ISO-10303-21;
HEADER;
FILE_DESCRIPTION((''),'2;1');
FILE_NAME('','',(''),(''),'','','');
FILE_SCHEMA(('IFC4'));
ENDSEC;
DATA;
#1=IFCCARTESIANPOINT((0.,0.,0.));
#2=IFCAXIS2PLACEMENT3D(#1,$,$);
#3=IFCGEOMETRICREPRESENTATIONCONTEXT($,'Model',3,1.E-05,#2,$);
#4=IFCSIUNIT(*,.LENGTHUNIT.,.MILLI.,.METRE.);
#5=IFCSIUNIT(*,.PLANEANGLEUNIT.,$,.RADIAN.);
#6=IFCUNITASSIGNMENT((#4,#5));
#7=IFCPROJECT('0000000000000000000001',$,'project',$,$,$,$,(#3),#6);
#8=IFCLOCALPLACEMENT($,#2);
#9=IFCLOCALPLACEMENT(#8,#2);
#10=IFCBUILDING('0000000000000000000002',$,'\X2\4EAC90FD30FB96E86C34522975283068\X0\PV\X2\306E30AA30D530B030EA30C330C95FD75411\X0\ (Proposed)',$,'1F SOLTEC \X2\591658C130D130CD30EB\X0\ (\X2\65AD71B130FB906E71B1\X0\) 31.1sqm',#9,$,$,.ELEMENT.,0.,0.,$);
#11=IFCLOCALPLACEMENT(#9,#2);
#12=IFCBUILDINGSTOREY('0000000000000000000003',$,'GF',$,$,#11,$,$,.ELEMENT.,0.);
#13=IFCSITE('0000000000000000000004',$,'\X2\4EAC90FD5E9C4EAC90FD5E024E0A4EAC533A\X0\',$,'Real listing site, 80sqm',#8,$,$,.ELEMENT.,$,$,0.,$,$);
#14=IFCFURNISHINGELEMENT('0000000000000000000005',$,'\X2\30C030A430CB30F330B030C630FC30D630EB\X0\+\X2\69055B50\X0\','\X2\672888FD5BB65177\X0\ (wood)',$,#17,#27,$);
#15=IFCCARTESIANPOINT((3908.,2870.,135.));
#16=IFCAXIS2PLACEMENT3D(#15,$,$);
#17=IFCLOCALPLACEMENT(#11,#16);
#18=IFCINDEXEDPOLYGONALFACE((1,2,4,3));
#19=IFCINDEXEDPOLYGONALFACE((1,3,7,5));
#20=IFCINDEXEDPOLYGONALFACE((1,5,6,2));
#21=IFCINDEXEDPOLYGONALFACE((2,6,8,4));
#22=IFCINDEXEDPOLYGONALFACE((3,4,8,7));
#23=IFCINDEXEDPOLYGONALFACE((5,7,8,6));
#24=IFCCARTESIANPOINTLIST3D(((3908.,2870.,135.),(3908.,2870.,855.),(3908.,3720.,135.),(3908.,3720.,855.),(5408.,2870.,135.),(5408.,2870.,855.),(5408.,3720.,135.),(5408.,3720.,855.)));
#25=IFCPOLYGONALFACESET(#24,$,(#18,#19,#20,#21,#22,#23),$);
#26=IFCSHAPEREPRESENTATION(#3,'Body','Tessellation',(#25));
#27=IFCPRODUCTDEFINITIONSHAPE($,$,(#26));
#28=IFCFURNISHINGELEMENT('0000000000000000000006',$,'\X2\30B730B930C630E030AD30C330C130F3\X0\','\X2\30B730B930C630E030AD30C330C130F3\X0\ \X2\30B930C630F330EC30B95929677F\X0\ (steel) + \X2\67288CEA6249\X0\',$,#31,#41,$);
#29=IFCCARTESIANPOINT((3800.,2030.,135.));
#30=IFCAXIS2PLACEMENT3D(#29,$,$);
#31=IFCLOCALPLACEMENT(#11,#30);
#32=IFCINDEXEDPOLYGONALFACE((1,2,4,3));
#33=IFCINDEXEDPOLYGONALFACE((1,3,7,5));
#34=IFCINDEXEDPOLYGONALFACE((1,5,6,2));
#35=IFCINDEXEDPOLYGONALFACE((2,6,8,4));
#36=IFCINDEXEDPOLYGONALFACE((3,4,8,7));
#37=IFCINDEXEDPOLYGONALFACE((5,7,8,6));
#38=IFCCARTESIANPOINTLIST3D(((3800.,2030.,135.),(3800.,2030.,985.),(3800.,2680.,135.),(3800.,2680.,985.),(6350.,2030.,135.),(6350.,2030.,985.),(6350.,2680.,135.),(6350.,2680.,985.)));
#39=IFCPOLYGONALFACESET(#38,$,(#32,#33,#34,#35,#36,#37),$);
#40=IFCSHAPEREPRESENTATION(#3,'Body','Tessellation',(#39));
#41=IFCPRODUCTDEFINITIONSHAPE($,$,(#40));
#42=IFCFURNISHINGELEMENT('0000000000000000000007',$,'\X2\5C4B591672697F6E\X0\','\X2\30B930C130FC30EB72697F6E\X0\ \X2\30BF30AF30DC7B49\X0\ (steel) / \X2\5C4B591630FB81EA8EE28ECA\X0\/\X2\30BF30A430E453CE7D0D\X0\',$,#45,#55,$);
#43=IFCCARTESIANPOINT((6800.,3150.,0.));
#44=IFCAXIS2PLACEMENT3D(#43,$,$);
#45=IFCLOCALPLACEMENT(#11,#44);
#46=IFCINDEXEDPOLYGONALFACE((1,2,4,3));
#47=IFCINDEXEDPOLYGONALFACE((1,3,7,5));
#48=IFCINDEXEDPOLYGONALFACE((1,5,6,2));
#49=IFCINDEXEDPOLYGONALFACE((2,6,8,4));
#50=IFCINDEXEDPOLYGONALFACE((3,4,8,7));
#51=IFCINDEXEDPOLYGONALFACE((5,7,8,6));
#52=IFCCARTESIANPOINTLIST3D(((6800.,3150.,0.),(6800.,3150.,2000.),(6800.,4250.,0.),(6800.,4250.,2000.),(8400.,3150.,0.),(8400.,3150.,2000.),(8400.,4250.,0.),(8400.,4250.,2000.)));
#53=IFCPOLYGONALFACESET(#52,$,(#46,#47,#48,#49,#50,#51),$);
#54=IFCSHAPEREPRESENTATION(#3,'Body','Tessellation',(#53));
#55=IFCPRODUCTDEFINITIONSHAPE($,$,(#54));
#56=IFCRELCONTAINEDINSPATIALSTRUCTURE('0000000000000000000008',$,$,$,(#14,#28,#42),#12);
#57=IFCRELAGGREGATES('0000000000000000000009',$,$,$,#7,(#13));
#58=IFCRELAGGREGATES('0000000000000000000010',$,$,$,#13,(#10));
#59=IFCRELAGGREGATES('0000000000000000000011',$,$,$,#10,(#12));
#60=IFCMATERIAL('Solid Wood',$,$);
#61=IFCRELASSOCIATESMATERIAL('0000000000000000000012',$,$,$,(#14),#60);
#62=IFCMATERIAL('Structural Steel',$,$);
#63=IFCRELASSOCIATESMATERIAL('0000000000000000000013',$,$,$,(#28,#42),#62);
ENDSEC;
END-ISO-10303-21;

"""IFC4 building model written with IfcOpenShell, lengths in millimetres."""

from ifc_helpers import new_model, si_unit, frame, frame_2d, origin, place, context, project, spatial, rectangle, extrude, material, element, save


model = new_model("IFC4")

# Units and contexts
model_context = context("Model", 3, precision=1e-05, world=origin())
ifc_project = project(units=[si_unit("LENGTHUNIT", "METRE", prefix="MILLI"), si_unit("PLANEANGLEUNIT", "RADIAN")], contexts=[model_context])

# Site, building, storey
site_placement = place(None, origin())
site = spatial("IfcSite", under=ifc_project, at=site_placement, Name="京都府京都市上京区", ObjectType="Real listing site, 80sqm", CompositionType="ELEMENT", RefElevation=0.0)
building_placement = place(site_placement, origin())
building = spatial("IfcBuilding", under=site, at=building_placement, Name="京都・雨水利用とPVのオフグリッド志向 (Proposed)", ObjectType="1F SOLTEC 外壁パネル (断熱・遮熱) 31.1sqm", CompositionType="ELEMENT", ElevationOfRefHeight=0.0, ElevationOfTerrain=0.0)
storey_placement = place(building_placement, origin())
storey = spatial("IfcBuildingStorey", under=building, at=storey_placement, Name="GF", CompositionType="ELEMENT", Elevation=0.0)

# Shared definitions
ifc_material_1 = material(Name="Solid Wood")

# Shared definitions
ifc_material_2 = material(Name="Structural Steel")

# Furnishing elements
furnishing_1_placement = place(storey_placement, frame((3908.0, 2870.0, 135.0)))
element("IfcFurnishingElement", 1, at=furnishing_1_placement, inside=storey, material=ifc_material_1, Name="ダイニングテーブル+椅子", Description="木製家具 (wood)", context=model_context, shape_type="SweptSolid", body=[
    extrude(rectangle(XDim=1500.0, YDim=850.0, at=frame_2d((750.0, 425.0))), frame((3908.0, 2870.0, 135.0)), (0.0, 0.0, 1.0), 720.0),
])
furnishing_2_placement = place(storey_placement, frame((3800.0, 2030.0, 135.0)))
element("IfcFurnishingElement", 2, at=furnishing_2_placement, inside=storey, material=ifc_material_2, Name="システムキッチン", Description="システムキッチン ステンレス天板 (steel) + 木質扉", context=model_context, shape_type="SweptSolid", body=[
    extrude(rectangle(XDim=2550.0, YDim=650.0, at=frame_2d((1275.0, 325.0))), frame((3800.0, 2030.0, 135.0)), (0.0, 0.0, 1.0), 850.0),
])
furnishing_3_placement = place(storey_placement, frame((6800.0, 3150.0, 0.0)))
element("IfcFurnishingElement", 3, at=furnishing_3_placement, inside=storey, material=ifc_material_2, Name="屋外物置", Description="スチール物置 タクボ等 (steel) / 屋外・自転車/タイヤ収納", context=model_context, shape_type="SweptSolid", body=[
    extrude(rectangle(XDim=1600.0, YDim=1100.0, at=frame_2d((800.0, 550.0))), frame((6800.0, 3150.0, 0.0)), (0.0, 0.0, 1.0), 2000.0),
])

save(model, "model.ifc")
